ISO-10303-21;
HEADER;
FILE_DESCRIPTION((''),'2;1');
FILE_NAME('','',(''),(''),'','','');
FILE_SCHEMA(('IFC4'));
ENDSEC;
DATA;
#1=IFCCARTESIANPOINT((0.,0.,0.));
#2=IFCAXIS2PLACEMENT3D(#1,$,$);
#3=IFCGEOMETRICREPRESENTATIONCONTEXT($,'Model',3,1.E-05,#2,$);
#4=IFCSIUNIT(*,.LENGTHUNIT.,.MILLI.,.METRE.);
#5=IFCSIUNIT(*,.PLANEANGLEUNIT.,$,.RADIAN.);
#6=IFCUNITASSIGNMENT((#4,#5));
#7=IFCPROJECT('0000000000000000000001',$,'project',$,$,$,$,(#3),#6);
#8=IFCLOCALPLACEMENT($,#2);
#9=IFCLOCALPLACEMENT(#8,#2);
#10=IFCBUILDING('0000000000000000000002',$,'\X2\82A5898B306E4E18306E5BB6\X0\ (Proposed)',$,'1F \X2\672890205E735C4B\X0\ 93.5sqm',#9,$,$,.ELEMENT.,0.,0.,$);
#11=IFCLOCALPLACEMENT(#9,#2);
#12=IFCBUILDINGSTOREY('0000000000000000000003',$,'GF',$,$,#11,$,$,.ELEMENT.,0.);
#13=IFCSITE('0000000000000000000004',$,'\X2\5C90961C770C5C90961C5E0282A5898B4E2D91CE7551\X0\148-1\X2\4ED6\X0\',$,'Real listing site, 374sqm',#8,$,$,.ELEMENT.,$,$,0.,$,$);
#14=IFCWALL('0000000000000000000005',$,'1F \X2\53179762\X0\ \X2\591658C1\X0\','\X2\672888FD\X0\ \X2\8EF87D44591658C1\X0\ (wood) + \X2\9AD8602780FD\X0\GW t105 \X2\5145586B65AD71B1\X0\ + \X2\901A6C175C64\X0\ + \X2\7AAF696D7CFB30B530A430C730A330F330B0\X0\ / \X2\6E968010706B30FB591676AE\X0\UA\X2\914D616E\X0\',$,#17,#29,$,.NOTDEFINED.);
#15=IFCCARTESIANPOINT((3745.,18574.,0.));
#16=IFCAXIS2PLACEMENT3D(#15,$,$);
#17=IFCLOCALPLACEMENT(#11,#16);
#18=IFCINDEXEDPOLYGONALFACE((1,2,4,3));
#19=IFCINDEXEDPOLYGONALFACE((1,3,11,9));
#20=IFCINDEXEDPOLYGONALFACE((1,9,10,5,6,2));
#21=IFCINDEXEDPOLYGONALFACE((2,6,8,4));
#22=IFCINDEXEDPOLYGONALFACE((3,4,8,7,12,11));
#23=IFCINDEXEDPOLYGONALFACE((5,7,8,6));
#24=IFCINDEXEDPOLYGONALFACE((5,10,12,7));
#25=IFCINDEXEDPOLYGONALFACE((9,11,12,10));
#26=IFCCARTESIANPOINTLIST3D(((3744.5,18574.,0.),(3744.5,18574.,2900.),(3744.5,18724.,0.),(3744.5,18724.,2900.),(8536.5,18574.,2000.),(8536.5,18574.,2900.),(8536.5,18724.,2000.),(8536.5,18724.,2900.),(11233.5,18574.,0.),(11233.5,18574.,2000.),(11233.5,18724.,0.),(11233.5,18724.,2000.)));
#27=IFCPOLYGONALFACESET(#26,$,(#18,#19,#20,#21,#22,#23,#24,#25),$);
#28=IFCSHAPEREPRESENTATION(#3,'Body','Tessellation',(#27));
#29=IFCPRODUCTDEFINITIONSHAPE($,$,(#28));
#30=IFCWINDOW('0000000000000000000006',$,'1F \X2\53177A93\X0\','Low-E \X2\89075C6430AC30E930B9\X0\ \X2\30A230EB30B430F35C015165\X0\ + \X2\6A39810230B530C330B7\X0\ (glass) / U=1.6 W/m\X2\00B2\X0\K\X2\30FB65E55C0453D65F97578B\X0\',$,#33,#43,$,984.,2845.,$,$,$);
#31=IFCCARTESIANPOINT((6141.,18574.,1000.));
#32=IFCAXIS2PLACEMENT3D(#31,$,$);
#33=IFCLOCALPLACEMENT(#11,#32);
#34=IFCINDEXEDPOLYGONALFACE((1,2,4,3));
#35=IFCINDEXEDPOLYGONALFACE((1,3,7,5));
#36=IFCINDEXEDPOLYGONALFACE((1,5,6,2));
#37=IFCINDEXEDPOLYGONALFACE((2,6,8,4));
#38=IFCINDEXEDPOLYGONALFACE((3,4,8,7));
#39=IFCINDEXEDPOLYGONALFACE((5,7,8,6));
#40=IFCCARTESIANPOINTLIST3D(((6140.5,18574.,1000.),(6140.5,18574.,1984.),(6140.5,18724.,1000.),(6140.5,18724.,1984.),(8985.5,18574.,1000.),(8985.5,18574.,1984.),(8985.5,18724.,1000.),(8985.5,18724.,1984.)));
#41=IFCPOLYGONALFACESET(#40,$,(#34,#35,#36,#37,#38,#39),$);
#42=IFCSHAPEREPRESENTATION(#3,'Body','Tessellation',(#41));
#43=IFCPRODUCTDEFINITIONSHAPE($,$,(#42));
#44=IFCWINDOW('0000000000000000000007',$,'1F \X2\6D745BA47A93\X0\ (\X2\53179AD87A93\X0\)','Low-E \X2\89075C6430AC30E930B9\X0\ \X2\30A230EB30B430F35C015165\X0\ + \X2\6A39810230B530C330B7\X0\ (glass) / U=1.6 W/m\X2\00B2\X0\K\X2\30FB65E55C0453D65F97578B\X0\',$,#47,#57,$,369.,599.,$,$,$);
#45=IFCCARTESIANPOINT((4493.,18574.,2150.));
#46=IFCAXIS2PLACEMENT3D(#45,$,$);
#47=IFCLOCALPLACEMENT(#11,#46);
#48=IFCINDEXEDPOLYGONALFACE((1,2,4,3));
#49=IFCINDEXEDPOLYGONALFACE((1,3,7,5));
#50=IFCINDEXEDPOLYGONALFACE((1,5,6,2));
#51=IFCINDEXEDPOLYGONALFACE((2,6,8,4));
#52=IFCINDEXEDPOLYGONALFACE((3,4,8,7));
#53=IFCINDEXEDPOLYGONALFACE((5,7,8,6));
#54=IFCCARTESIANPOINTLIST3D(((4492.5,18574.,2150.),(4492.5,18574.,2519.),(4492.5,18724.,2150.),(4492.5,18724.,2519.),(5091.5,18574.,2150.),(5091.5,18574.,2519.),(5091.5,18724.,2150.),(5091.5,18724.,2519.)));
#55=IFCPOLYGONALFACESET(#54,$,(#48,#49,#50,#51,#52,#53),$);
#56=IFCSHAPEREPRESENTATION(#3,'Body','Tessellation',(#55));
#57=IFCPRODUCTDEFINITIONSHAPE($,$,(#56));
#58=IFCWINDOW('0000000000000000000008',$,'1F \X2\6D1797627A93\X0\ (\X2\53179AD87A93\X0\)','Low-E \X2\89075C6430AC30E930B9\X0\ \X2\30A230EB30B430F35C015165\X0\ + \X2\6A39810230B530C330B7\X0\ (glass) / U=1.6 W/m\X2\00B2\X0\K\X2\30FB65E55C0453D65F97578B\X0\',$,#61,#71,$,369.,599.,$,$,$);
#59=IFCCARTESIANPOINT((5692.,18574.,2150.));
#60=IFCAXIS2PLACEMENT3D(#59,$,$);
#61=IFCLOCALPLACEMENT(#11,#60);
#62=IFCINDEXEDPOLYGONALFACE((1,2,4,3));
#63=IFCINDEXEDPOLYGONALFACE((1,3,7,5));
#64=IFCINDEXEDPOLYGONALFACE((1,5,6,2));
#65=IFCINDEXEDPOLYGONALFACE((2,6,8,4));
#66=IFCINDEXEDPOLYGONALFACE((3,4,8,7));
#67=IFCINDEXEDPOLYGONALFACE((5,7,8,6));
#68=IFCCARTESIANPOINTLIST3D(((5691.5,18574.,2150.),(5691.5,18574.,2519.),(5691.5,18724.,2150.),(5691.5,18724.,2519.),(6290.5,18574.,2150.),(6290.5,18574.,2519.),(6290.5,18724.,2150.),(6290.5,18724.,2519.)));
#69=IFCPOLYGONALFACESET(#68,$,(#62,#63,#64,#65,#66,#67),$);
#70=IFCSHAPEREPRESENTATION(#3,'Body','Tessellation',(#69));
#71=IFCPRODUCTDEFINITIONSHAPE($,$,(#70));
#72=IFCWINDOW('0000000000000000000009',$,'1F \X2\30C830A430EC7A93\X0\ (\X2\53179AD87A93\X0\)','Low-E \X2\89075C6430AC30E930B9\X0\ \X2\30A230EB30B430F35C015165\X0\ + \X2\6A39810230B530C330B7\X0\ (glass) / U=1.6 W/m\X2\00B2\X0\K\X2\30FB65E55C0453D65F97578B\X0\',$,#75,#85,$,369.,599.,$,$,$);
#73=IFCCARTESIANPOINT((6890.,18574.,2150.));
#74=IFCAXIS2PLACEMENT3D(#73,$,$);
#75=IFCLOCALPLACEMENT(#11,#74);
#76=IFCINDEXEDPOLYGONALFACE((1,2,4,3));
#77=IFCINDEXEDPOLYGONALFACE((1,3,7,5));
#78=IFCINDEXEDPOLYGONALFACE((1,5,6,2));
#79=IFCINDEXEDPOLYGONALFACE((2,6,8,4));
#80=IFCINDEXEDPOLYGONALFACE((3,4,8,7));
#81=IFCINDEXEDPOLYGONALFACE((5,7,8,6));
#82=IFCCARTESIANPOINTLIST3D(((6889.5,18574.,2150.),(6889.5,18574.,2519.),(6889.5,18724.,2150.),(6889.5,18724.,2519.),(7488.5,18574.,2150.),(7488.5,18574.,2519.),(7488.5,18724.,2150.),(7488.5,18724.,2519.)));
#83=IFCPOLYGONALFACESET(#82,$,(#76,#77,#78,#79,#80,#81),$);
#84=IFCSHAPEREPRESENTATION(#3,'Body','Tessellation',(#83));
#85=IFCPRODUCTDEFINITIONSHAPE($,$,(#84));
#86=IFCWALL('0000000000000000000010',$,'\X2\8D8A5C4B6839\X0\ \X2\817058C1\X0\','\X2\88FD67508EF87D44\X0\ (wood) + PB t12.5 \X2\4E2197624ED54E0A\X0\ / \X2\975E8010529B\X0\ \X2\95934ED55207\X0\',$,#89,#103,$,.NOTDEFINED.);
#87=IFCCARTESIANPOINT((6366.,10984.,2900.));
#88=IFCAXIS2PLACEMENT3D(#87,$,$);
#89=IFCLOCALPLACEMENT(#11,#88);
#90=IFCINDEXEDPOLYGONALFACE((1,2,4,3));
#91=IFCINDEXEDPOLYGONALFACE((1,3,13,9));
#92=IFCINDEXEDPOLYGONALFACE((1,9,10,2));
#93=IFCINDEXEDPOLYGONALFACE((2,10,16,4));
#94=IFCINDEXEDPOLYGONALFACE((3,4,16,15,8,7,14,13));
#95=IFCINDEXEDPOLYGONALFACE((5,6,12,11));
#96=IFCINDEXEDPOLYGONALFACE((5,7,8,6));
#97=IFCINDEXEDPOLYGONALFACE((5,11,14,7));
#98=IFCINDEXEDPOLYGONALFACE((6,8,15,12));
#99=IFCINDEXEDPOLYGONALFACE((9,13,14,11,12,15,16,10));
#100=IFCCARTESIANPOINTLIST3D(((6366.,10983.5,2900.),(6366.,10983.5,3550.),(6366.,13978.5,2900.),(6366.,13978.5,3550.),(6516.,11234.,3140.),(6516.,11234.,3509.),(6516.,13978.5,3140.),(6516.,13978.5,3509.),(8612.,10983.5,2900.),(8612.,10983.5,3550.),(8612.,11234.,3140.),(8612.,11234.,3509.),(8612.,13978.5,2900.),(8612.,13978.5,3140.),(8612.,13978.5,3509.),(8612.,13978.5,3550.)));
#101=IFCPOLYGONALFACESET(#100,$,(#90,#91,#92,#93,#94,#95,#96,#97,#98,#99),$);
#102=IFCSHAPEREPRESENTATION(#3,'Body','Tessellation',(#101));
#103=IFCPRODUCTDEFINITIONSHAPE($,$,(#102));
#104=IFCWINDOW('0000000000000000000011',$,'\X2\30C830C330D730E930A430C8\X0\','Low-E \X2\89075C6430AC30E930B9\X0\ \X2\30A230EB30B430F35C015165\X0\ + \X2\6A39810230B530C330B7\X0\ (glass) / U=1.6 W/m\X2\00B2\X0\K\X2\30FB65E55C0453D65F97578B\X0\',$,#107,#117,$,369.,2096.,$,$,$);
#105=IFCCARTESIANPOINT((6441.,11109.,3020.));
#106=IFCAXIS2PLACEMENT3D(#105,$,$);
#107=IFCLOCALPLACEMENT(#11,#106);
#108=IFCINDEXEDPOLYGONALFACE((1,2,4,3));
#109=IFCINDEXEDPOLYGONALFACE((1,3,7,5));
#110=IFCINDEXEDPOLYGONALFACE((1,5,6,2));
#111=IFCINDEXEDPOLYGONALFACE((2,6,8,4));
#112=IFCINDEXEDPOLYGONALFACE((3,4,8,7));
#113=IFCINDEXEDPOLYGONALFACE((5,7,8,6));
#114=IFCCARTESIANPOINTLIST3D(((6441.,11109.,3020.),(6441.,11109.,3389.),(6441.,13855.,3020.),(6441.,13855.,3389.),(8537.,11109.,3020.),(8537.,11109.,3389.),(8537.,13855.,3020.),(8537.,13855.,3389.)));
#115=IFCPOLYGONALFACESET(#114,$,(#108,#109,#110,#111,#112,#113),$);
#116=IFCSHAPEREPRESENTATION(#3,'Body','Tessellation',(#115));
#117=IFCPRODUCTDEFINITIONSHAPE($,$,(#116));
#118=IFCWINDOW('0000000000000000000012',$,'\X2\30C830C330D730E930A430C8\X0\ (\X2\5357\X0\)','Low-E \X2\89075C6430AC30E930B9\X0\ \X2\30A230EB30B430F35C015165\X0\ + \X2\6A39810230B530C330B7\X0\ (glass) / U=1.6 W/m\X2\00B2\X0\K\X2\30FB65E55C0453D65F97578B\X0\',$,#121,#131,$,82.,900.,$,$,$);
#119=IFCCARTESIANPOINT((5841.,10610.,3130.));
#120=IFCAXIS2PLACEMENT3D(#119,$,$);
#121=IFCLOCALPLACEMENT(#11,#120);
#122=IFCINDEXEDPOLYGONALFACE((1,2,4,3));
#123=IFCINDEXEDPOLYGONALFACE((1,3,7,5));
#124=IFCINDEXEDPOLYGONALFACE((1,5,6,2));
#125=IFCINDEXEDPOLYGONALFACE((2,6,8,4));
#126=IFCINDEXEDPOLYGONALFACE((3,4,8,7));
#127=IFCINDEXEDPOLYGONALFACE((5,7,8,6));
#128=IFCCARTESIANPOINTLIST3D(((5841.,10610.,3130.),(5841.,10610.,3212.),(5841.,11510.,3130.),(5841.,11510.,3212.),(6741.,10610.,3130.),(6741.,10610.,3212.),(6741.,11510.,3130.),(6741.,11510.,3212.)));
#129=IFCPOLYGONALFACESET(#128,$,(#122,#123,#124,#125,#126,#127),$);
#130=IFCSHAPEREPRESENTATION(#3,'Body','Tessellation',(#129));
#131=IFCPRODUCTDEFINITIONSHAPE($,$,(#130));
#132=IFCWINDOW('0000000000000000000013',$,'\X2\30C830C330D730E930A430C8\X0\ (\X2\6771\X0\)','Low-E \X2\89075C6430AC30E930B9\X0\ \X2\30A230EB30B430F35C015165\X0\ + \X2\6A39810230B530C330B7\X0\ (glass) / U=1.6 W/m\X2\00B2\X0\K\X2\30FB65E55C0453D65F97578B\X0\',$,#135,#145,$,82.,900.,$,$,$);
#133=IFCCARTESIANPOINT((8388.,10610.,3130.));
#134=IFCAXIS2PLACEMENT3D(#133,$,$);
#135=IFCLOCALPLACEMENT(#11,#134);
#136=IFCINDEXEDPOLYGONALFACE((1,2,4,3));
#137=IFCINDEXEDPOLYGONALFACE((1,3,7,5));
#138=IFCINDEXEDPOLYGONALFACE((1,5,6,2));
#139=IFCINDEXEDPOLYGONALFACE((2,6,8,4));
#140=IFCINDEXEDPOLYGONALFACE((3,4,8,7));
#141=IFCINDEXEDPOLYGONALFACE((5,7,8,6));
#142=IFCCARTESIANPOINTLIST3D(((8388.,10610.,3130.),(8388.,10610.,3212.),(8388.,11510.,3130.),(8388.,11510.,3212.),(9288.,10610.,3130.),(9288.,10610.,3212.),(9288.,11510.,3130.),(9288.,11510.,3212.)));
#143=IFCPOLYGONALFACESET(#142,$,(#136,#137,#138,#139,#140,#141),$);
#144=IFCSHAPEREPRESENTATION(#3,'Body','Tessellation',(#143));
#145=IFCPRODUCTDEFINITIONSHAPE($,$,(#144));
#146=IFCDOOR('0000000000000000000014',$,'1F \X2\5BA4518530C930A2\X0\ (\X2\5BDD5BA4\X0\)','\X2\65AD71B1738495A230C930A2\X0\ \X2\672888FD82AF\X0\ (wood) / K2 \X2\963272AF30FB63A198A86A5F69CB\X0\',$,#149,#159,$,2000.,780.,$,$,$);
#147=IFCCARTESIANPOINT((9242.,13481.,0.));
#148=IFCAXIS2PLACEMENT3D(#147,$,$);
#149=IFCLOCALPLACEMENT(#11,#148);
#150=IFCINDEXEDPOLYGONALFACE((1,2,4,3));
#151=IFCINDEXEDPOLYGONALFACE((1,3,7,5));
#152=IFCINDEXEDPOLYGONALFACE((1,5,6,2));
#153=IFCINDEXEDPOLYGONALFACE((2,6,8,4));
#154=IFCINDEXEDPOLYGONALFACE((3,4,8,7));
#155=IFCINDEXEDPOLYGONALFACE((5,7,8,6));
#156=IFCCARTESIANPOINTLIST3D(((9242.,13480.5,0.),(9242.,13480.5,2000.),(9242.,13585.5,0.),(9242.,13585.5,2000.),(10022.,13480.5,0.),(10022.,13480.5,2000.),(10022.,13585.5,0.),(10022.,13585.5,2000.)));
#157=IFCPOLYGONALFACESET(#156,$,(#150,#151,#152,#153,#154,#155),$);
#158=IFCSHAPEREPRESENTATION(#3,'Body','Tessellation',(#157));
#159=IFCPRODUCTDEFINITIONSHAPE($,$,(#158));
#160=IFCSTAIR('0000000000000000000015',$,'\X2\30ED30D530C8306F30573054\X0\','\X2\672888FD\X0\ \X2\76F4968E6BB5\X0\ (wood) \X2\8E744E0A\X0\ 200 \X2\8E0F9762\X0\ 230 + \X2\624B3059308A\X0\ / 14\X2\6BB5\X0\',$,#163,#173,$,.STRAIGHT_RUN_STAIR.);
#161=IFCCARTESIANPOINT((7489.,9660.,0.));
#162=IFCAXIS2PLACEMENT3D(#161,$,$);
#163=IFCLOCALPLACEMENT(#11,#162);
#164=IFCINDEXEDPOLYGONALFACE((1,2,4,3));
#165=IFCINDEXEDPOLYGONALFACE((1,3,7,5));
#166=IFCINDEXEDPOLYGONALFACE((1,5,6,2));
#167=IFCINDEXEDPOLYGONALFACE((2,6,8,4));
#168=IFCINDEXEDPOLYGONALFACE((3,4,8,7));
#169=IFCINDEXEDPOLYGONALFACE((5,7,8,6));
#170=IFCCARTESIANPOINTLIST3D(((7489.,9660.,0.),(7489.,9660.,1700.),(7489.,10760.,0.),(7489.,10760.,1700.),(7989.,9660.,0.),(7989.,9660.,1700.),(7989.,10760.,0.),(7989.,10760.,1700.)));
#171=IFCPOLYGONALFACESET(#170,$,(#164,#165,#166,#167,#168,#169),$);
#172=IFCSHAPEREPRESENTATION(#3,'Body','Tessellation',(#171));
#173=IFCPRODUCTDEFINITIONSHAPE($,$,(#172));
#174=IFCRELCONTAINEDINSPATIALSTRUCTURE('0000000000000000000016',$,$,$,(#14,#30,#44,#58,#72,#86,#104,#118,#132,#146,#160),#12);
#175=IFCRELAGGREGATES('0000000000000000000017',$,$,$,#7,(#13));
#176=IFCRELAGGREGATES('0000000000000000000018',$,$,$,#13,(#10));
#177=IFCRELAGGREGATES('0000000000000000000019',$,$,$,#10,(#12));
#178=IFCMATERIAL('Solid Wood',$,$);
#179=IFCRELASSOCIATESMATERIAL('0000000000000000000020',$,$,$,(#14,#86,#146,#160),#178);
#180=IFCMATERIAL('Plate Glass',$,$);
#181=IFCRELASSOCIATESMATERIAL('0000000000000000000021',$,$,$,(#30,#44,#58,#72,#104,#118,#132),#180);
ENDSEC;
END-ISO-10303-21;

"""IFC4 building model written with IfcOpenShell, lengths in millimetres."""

from ifc_helpers import new_model, si_unit, frame, frame_2d, origin, place, context, project, spatial, rectangle, extrude, material, element, fill, save


model = new_model("IFC4")

# Units and contexts
model_context = context("Model", 3, precision=1e-05, world=origin())
ifc_project = project(units=[si_unit("LENGTHUNIT", "METRE", prefix="MILLI"), si_unit("PLANEANGLEUNIT", "RADIAN")], contexts=[model_context])

# Site, building, storey
site_placement = place(None, origin())
site = spatial("IfcSite", under=ifc_project, at=site_placement, Name="岐阜県岐阜市芥見中野畑148-1他", ObjectType="Real listing site, 374sqm", CompositionType="ELEMENT", RefElevation=0.0)
building_placement = place(site_placement, origin())
building = spatial("IfcBuilding", under=site, at=building_placement, Name="芥見の丘の家 (Proposed)", ObjectType="1F 木造平屋 93.5sqm", CompositionType="ELEMENT", ElevationOfRefHeight=0.0, ElevationOfTerrain=0.0)
storey_placement = place(building_placement, origin())
storey = spatial("IfcBuildingStorey", under=building, at=storey_placement, Name="GF", CompositionType="ELEMENT", Elevation=0.0)

# Shared definitions
ifc_material_1 = material(Name="Solid Wood")

# Wall, openings, windows
wall_1_placement = place(storey_placement, frame((3745.0, 18574.0, 0.0)))
wall_1 = element("IfcWall", 1, at=wall_1_placement, inside=storey, material=ifc_material_1, Name="1F 北面 外壁", Description="木製 軸組外壁 (wood) + 高性能GW t105 充填断熱 + 通気層 + 窯業系サイディング / 準耐火・外皮UA配慮", PredefinedType="NOTDEFINED", context=model_context, shape_type="SweptSolid", body=[
    extrude(rectangle(XDim=7489.0, YDim=150.0, at=frame_2d((3744.0, 75.0))), frame((3745.0, 18574.0, 0.0)), (0.0, 0.0, 1.0), 2900.0),
])
opening_1_placement = place(storey_placement, frame((6141.0, 18574.0, 1000.0)))
opening_1 = element("IfcOpeningElement", 2, at=opening_1_placement, cuts=wall_1, PredefinedType="NOTDEFINED", context=model_context, shape_type="SweptSolid", body=[
    extrude(rectangle(XDim=2845.0, YDim=150.0, at=frame_2d((1422.0, 75.0))), frame((6141.0, 18574.0, 1000.0)), (0.0, 0.0, 1.0), 984.0),
])
opening_2_placement = place(storey_placement, frame((4493.0, 18574.0, 2150.0)))
opening_2 = element("IfcOpeningElement", 3, at=opening_2_placement, cuts=wall_1, PredefinedType="NOTDEFINED", context=model_context, shape_type="SweptSolid", body=[
    extrude(rectangle(XDim=599.0, YDim=150.0, at=frame_2d((299.0, 75.0))), frame((4493.0, 18574.0, 2150.0)), (0.0, 0.0, 1.0), 369.0),
])
opening_3_placement = place(storey_placement, frame((5692.0, 18574.0, 2150.0)))
opening_3 = element("IfcOpeningElement", 4, at=opening_3_placement, cuts=wall_1, PredefinedType="NOTDEFINED", context=model_context, shape_type="SweptSolid", body=[
    extrude(rectangle(XDim=599.0, YDim=150.0, at=frame_2d((299.0, 75.0))), frame((5692.0, 18574.0, 2150.0)), (0.0, 0.0, 1.0), 369.0),
])
opening_4_placement = place(storey_placement, frame((6890.0, 18574.0, 2150.0)))
opening_4 = element("IfcOpeningElement", 5, at=opening_4_placement, cuts=wall_1, PredefinedType="NOTDEFINED", context=model_context, shape_type="SweptSolid", body=[
    extrude(rectangle(XDim=599.0, YDim=150.0, at=frame_2d((299.0, 75.0))), frame((6890.0, 18574.0, 2150.0)), (0.0, 0.0, 1.0), 369.0),
])
ifc_material_2 = material(Name="Plate Glass")
window_1_placement = place(storey_placement, frame((6141.0, 18574.0, 1000.0)))
window_1 = element("IfcWindow", 6, at=window_1_placement, inside=storey, material=ifc_material_2, Name="1F 北窓", Description="Low-E 複層ガラス アルゴン封入 + 樹脂サッシ (glass) / U=1.6 W/m²K・日射取得型", OverallHeight=984.0, OverallWidth=2845.0, context=model_context, shape_type="SweptSolid", body=[
    extrude(rectangle(XDim=2845.0, YDim=150.0, at=frame_2d((1422.0, 75.0))), frame((6141.0, 18574.0, 1000.0)), (0.0, 0.0, 1.0), 984.0),
])
fill(opening_1, window_1)
window_2_placement = place(storey_placement, frame((4493.0, 18574.0, 2150.0)))
window_2 = element("IfcWindow", 7, at=window_2_placement, inside=storey, material=ifc_material_2, Name="1F 浴室窓 (北高窓)", Description="Low-E 複層ガラス アルゴン封入 + 樹脂サッシ (glass) / U=1.6 W/m²K・日射取得型", OverallHeight=369.0, OverallWidth=599.0, context=model_context, shape_type="SweptSolid", body=[
    extrude(rectangle(XDim=599.0, YDim=150.0, at=frame_2d((299.0, 75.0))), frame((4493.0, 18574.0, 2150.0)), (0.0, 0.0, 1.0), 369.0),
])
fill(opening_2, window_2)
window_3_placement = place(storey_placement, frame((5692.0, 18574.0, 2150.0)))
window_3 = element("IfcWindow", 8, at=window_3_placement, inside=storey, material=ifc_material_2, Name="1F 洗面窓 (北高窓)", Description="Low-E 複層ガラス アルゴン封入 + 樹脂サッシ (glass) / U=1.6 W/m²K・日射取得型", OverallHeight=369.0, OverallWidth=599.0, context=model_context, shape_type="SweptSolid", body=[
    extrude(rectangle(XDim=599.0, YDim=150.0, at=frame_2d((299.0, 75.0))), frame((5692.0, 18574.0, 2150.0)), (0.0, 0.0, 1.0), 369.0),
])
fill(opening_3, window_3)
window_4_placement = place(storey_placement, frame((6890.0, 18574.0, 2150.0)))
window_4 = element("IfcWindow", 9, at=window_4_placement, inside=storey, material=ifc_material_2, Name="1F トイレ窓 (北高窓)", Description="Low-E 複層ガラス アルゴン封入 + 樹脂サッシ (glass) / U=1.6 W/m²K・日射取得型", OverallHeight=369.0, OverallWidth=599.0, context=model_context, shape_type="SweptSolid", body=[
    extrude(rectangle(XDim=599.0, YDim=150.0, at=frame_2d((299.0, 75.0))), frame((6890.0, 18574.0, 2150.0)), (0.0, 0.0, 1.0), 369.0),
])
fill(opening_4, window_4)

# Wall, openings, windows
wall_2_placement = place(storey_placement, frame((6366.0, 10984.0, 2900.0)))
wall_2 = element("IfcWall", 10, at=wall_2_placement, inside=storey, material=ifc_material_1, Name="越屋根 腰壁", Description="製材軸組 (wood) + PB t12.5 両面仕上 / 非耐力 間仕切", PredefinedType="NOTDEFINED", context=model_context, shape_type="SweptSolid", body=[
    extrude(rectangle(XDim=2246.0, YDim=2995.0, at=frame_2d((1123.0, 1497.0))), frame((6366.0, 10984.0, 2900.0)), (0.0, 0.0, 1.0), 650.0),
])
opening_5_placement = place(storey_placement, frame((6441.0, 11109.0, 3020.0)))
opening_5 = element("IfcOpeningElement", 11, at=opening_5_placement, cuts=wall_2, PredefinedType="NOTDEFINED", context=model_context, shape_type="SweptSolid", body=[
    extrude(rectangle(XDim=2096.0, YDim=2746.0, at=frame_2d((1048.0, 1373.0))), frame((6441.0, 11109.0, 3020.0)), (0.0, 0.0, 1.0), 369.0),
])
opening_6_placement = place(storey_placement, frame((5841.0, 10610.0, 3130.0)))
opening_6 = element("IfcOpeningElement", 12, at=opening_6_placement, cuts=wall_2, PredefinedType="NOTDEFINED", context=model_context, shape_type="SweptSolid", body=[
    extrude(rectangle(XDim=900.0, YDim=900.0, at=frame_2d((450.0, 450.0))), frame((5841.0, 10610.0, 3130.0)), (0.0, 0.0, 1.0), 82.0),
])
opening_7_placement = place(storey_placement, frame((8388.0, 10610.0, 3130.0)))
opening_7 = element("IfcOpeningElement", 13, at=opening_7_placement, cuts=wall_2, PredefinedType="NOTDEFINED", context=model_context, shape_type="SweptSolid", body=[
    extrude(rectangle(XDim=900.0, YDim=900.0, at=frame_2d((450.0, 450.0))), frame((8388.0, 10610.0, 3130.0)), (0.0, 0.0, 1.0), 82.0),
])
window_5_placement = place(storey_placement, frame((6441.0, 11109.0, 3020.0)))
window_5 = element("IfcWindow", 14, at=window_5_placement, inside=storey, material=ifc_material_2, Name="トップライト", Description="Low-E 複層ガラス アルゴン封入 + 樹脂サッシ (glass) / U=1.6 W/m²K・日射取得型", OverallHeight=369.0, OverallWidth=2096.0, context=model_context, shape_type="SweptSolid", body=[
    extrude(rectangle(XDim=2096.0, YDim=2746.0, at=frame_2d((1048.0, 1373.0))), frame((6441.0, 11109.0, 3020.0)), (0.0, 0.0, 1.0), 369.0),
])
fill(opening_5, window_5)
window_6_placement = place(storey_placement, frame((5841.0, 10610.0, 3130.0)))
window_6 = element("IfcWindow", 15, at=window_6_placement, inside=storey, material=ifc_material_2, Name="トップライト (南)", Description="Low-E 複層ガラス アルゴン封入 + 樹脂サッシ (glass) / U=1.6 W/m²K・日射取得型", OverallHeight=82.0, OverallWidth=900.0, context=model_context, shape_type="SweptSolid", body=[
    extrude(rectangle(XDim=900.0, YDim=900.0, at=frame_2d((450.0, 450.0))), frame((5841.0, 10610.0, 3130.0)), (0.0, 0.0, 1.0), 82.0),
])
fill(opening_6, window_6)
window_7_placement = place(storey_placement, frame((8388.0, 10610.0, 3130.0)))
window_7 = element("IfcWindow", 16, at=window_7_placement, inside=storey, material=ifc_material_2, Name="トップライト (東)", Description="Low-E 複層ガラス アルゴン封入 + 樹脂サッシ (glass) / U=1.6 W/m²K・日射取得型", OverallHeight=82.0, OverallWidth=900.0, context=model_context, shape_type="SweptSolid", body=[
    extrude(rectangle(XDim=900.0, YDim=900.0, at=frame_2d((450.0, 450.0))), frame((8388.0, 10610.0, 3130.0)), (0.0, 0.0, 1.0), 82.0),
])
fill(opening_7, window_7)

# Door
door_1_placement = place(storey_placement, frame((9242.0, 13481.0, 0.0)))
element("IfcDoor", 17, at=door_1_placement, inside=storey, material=ifc_material_1, Name="1F 室内ドア (寝室)", Description="断熱玄関ドア 木製芯 (wood) / K2 防犯・採風機構", OverallHeight=2000.0, OverallWidth=780.0, context=model_context, shape_type="SweptSolid", body=[
    extrude(rectangle(XDim=780.0, YDim=105.0, at=frame_2d((390.0, 52.0))), frame((9242.0, 13481.0, 0.0)), (0.0, 0.0, 1.0), 2000.0),
])

# Stair
stair_placement = place(storey_placement, frame((7489.0, 9660.0, 0.0)))
element("IfcStair", 18, at=stair_placement, inside=storey, material=ifc_material_1, Name="ロフトはしご", Description="木製 直階段 (wood) 蹴上 200 踏面 230 + 手すり / 14段", PredefinedType="STRAIGHT_RUN_STAIR", context=model_context, shape_type="SweptSolid", body=[
    extrude(rectangle(XDim=500.0, YDim=1100.0, at=frame_2d((250.0, 550.0))), frame((7489.0, 9660.0, 0.0)), (0.0, 0.0, 1.0), 1700.0),
])

save(model, "model.ifc")
